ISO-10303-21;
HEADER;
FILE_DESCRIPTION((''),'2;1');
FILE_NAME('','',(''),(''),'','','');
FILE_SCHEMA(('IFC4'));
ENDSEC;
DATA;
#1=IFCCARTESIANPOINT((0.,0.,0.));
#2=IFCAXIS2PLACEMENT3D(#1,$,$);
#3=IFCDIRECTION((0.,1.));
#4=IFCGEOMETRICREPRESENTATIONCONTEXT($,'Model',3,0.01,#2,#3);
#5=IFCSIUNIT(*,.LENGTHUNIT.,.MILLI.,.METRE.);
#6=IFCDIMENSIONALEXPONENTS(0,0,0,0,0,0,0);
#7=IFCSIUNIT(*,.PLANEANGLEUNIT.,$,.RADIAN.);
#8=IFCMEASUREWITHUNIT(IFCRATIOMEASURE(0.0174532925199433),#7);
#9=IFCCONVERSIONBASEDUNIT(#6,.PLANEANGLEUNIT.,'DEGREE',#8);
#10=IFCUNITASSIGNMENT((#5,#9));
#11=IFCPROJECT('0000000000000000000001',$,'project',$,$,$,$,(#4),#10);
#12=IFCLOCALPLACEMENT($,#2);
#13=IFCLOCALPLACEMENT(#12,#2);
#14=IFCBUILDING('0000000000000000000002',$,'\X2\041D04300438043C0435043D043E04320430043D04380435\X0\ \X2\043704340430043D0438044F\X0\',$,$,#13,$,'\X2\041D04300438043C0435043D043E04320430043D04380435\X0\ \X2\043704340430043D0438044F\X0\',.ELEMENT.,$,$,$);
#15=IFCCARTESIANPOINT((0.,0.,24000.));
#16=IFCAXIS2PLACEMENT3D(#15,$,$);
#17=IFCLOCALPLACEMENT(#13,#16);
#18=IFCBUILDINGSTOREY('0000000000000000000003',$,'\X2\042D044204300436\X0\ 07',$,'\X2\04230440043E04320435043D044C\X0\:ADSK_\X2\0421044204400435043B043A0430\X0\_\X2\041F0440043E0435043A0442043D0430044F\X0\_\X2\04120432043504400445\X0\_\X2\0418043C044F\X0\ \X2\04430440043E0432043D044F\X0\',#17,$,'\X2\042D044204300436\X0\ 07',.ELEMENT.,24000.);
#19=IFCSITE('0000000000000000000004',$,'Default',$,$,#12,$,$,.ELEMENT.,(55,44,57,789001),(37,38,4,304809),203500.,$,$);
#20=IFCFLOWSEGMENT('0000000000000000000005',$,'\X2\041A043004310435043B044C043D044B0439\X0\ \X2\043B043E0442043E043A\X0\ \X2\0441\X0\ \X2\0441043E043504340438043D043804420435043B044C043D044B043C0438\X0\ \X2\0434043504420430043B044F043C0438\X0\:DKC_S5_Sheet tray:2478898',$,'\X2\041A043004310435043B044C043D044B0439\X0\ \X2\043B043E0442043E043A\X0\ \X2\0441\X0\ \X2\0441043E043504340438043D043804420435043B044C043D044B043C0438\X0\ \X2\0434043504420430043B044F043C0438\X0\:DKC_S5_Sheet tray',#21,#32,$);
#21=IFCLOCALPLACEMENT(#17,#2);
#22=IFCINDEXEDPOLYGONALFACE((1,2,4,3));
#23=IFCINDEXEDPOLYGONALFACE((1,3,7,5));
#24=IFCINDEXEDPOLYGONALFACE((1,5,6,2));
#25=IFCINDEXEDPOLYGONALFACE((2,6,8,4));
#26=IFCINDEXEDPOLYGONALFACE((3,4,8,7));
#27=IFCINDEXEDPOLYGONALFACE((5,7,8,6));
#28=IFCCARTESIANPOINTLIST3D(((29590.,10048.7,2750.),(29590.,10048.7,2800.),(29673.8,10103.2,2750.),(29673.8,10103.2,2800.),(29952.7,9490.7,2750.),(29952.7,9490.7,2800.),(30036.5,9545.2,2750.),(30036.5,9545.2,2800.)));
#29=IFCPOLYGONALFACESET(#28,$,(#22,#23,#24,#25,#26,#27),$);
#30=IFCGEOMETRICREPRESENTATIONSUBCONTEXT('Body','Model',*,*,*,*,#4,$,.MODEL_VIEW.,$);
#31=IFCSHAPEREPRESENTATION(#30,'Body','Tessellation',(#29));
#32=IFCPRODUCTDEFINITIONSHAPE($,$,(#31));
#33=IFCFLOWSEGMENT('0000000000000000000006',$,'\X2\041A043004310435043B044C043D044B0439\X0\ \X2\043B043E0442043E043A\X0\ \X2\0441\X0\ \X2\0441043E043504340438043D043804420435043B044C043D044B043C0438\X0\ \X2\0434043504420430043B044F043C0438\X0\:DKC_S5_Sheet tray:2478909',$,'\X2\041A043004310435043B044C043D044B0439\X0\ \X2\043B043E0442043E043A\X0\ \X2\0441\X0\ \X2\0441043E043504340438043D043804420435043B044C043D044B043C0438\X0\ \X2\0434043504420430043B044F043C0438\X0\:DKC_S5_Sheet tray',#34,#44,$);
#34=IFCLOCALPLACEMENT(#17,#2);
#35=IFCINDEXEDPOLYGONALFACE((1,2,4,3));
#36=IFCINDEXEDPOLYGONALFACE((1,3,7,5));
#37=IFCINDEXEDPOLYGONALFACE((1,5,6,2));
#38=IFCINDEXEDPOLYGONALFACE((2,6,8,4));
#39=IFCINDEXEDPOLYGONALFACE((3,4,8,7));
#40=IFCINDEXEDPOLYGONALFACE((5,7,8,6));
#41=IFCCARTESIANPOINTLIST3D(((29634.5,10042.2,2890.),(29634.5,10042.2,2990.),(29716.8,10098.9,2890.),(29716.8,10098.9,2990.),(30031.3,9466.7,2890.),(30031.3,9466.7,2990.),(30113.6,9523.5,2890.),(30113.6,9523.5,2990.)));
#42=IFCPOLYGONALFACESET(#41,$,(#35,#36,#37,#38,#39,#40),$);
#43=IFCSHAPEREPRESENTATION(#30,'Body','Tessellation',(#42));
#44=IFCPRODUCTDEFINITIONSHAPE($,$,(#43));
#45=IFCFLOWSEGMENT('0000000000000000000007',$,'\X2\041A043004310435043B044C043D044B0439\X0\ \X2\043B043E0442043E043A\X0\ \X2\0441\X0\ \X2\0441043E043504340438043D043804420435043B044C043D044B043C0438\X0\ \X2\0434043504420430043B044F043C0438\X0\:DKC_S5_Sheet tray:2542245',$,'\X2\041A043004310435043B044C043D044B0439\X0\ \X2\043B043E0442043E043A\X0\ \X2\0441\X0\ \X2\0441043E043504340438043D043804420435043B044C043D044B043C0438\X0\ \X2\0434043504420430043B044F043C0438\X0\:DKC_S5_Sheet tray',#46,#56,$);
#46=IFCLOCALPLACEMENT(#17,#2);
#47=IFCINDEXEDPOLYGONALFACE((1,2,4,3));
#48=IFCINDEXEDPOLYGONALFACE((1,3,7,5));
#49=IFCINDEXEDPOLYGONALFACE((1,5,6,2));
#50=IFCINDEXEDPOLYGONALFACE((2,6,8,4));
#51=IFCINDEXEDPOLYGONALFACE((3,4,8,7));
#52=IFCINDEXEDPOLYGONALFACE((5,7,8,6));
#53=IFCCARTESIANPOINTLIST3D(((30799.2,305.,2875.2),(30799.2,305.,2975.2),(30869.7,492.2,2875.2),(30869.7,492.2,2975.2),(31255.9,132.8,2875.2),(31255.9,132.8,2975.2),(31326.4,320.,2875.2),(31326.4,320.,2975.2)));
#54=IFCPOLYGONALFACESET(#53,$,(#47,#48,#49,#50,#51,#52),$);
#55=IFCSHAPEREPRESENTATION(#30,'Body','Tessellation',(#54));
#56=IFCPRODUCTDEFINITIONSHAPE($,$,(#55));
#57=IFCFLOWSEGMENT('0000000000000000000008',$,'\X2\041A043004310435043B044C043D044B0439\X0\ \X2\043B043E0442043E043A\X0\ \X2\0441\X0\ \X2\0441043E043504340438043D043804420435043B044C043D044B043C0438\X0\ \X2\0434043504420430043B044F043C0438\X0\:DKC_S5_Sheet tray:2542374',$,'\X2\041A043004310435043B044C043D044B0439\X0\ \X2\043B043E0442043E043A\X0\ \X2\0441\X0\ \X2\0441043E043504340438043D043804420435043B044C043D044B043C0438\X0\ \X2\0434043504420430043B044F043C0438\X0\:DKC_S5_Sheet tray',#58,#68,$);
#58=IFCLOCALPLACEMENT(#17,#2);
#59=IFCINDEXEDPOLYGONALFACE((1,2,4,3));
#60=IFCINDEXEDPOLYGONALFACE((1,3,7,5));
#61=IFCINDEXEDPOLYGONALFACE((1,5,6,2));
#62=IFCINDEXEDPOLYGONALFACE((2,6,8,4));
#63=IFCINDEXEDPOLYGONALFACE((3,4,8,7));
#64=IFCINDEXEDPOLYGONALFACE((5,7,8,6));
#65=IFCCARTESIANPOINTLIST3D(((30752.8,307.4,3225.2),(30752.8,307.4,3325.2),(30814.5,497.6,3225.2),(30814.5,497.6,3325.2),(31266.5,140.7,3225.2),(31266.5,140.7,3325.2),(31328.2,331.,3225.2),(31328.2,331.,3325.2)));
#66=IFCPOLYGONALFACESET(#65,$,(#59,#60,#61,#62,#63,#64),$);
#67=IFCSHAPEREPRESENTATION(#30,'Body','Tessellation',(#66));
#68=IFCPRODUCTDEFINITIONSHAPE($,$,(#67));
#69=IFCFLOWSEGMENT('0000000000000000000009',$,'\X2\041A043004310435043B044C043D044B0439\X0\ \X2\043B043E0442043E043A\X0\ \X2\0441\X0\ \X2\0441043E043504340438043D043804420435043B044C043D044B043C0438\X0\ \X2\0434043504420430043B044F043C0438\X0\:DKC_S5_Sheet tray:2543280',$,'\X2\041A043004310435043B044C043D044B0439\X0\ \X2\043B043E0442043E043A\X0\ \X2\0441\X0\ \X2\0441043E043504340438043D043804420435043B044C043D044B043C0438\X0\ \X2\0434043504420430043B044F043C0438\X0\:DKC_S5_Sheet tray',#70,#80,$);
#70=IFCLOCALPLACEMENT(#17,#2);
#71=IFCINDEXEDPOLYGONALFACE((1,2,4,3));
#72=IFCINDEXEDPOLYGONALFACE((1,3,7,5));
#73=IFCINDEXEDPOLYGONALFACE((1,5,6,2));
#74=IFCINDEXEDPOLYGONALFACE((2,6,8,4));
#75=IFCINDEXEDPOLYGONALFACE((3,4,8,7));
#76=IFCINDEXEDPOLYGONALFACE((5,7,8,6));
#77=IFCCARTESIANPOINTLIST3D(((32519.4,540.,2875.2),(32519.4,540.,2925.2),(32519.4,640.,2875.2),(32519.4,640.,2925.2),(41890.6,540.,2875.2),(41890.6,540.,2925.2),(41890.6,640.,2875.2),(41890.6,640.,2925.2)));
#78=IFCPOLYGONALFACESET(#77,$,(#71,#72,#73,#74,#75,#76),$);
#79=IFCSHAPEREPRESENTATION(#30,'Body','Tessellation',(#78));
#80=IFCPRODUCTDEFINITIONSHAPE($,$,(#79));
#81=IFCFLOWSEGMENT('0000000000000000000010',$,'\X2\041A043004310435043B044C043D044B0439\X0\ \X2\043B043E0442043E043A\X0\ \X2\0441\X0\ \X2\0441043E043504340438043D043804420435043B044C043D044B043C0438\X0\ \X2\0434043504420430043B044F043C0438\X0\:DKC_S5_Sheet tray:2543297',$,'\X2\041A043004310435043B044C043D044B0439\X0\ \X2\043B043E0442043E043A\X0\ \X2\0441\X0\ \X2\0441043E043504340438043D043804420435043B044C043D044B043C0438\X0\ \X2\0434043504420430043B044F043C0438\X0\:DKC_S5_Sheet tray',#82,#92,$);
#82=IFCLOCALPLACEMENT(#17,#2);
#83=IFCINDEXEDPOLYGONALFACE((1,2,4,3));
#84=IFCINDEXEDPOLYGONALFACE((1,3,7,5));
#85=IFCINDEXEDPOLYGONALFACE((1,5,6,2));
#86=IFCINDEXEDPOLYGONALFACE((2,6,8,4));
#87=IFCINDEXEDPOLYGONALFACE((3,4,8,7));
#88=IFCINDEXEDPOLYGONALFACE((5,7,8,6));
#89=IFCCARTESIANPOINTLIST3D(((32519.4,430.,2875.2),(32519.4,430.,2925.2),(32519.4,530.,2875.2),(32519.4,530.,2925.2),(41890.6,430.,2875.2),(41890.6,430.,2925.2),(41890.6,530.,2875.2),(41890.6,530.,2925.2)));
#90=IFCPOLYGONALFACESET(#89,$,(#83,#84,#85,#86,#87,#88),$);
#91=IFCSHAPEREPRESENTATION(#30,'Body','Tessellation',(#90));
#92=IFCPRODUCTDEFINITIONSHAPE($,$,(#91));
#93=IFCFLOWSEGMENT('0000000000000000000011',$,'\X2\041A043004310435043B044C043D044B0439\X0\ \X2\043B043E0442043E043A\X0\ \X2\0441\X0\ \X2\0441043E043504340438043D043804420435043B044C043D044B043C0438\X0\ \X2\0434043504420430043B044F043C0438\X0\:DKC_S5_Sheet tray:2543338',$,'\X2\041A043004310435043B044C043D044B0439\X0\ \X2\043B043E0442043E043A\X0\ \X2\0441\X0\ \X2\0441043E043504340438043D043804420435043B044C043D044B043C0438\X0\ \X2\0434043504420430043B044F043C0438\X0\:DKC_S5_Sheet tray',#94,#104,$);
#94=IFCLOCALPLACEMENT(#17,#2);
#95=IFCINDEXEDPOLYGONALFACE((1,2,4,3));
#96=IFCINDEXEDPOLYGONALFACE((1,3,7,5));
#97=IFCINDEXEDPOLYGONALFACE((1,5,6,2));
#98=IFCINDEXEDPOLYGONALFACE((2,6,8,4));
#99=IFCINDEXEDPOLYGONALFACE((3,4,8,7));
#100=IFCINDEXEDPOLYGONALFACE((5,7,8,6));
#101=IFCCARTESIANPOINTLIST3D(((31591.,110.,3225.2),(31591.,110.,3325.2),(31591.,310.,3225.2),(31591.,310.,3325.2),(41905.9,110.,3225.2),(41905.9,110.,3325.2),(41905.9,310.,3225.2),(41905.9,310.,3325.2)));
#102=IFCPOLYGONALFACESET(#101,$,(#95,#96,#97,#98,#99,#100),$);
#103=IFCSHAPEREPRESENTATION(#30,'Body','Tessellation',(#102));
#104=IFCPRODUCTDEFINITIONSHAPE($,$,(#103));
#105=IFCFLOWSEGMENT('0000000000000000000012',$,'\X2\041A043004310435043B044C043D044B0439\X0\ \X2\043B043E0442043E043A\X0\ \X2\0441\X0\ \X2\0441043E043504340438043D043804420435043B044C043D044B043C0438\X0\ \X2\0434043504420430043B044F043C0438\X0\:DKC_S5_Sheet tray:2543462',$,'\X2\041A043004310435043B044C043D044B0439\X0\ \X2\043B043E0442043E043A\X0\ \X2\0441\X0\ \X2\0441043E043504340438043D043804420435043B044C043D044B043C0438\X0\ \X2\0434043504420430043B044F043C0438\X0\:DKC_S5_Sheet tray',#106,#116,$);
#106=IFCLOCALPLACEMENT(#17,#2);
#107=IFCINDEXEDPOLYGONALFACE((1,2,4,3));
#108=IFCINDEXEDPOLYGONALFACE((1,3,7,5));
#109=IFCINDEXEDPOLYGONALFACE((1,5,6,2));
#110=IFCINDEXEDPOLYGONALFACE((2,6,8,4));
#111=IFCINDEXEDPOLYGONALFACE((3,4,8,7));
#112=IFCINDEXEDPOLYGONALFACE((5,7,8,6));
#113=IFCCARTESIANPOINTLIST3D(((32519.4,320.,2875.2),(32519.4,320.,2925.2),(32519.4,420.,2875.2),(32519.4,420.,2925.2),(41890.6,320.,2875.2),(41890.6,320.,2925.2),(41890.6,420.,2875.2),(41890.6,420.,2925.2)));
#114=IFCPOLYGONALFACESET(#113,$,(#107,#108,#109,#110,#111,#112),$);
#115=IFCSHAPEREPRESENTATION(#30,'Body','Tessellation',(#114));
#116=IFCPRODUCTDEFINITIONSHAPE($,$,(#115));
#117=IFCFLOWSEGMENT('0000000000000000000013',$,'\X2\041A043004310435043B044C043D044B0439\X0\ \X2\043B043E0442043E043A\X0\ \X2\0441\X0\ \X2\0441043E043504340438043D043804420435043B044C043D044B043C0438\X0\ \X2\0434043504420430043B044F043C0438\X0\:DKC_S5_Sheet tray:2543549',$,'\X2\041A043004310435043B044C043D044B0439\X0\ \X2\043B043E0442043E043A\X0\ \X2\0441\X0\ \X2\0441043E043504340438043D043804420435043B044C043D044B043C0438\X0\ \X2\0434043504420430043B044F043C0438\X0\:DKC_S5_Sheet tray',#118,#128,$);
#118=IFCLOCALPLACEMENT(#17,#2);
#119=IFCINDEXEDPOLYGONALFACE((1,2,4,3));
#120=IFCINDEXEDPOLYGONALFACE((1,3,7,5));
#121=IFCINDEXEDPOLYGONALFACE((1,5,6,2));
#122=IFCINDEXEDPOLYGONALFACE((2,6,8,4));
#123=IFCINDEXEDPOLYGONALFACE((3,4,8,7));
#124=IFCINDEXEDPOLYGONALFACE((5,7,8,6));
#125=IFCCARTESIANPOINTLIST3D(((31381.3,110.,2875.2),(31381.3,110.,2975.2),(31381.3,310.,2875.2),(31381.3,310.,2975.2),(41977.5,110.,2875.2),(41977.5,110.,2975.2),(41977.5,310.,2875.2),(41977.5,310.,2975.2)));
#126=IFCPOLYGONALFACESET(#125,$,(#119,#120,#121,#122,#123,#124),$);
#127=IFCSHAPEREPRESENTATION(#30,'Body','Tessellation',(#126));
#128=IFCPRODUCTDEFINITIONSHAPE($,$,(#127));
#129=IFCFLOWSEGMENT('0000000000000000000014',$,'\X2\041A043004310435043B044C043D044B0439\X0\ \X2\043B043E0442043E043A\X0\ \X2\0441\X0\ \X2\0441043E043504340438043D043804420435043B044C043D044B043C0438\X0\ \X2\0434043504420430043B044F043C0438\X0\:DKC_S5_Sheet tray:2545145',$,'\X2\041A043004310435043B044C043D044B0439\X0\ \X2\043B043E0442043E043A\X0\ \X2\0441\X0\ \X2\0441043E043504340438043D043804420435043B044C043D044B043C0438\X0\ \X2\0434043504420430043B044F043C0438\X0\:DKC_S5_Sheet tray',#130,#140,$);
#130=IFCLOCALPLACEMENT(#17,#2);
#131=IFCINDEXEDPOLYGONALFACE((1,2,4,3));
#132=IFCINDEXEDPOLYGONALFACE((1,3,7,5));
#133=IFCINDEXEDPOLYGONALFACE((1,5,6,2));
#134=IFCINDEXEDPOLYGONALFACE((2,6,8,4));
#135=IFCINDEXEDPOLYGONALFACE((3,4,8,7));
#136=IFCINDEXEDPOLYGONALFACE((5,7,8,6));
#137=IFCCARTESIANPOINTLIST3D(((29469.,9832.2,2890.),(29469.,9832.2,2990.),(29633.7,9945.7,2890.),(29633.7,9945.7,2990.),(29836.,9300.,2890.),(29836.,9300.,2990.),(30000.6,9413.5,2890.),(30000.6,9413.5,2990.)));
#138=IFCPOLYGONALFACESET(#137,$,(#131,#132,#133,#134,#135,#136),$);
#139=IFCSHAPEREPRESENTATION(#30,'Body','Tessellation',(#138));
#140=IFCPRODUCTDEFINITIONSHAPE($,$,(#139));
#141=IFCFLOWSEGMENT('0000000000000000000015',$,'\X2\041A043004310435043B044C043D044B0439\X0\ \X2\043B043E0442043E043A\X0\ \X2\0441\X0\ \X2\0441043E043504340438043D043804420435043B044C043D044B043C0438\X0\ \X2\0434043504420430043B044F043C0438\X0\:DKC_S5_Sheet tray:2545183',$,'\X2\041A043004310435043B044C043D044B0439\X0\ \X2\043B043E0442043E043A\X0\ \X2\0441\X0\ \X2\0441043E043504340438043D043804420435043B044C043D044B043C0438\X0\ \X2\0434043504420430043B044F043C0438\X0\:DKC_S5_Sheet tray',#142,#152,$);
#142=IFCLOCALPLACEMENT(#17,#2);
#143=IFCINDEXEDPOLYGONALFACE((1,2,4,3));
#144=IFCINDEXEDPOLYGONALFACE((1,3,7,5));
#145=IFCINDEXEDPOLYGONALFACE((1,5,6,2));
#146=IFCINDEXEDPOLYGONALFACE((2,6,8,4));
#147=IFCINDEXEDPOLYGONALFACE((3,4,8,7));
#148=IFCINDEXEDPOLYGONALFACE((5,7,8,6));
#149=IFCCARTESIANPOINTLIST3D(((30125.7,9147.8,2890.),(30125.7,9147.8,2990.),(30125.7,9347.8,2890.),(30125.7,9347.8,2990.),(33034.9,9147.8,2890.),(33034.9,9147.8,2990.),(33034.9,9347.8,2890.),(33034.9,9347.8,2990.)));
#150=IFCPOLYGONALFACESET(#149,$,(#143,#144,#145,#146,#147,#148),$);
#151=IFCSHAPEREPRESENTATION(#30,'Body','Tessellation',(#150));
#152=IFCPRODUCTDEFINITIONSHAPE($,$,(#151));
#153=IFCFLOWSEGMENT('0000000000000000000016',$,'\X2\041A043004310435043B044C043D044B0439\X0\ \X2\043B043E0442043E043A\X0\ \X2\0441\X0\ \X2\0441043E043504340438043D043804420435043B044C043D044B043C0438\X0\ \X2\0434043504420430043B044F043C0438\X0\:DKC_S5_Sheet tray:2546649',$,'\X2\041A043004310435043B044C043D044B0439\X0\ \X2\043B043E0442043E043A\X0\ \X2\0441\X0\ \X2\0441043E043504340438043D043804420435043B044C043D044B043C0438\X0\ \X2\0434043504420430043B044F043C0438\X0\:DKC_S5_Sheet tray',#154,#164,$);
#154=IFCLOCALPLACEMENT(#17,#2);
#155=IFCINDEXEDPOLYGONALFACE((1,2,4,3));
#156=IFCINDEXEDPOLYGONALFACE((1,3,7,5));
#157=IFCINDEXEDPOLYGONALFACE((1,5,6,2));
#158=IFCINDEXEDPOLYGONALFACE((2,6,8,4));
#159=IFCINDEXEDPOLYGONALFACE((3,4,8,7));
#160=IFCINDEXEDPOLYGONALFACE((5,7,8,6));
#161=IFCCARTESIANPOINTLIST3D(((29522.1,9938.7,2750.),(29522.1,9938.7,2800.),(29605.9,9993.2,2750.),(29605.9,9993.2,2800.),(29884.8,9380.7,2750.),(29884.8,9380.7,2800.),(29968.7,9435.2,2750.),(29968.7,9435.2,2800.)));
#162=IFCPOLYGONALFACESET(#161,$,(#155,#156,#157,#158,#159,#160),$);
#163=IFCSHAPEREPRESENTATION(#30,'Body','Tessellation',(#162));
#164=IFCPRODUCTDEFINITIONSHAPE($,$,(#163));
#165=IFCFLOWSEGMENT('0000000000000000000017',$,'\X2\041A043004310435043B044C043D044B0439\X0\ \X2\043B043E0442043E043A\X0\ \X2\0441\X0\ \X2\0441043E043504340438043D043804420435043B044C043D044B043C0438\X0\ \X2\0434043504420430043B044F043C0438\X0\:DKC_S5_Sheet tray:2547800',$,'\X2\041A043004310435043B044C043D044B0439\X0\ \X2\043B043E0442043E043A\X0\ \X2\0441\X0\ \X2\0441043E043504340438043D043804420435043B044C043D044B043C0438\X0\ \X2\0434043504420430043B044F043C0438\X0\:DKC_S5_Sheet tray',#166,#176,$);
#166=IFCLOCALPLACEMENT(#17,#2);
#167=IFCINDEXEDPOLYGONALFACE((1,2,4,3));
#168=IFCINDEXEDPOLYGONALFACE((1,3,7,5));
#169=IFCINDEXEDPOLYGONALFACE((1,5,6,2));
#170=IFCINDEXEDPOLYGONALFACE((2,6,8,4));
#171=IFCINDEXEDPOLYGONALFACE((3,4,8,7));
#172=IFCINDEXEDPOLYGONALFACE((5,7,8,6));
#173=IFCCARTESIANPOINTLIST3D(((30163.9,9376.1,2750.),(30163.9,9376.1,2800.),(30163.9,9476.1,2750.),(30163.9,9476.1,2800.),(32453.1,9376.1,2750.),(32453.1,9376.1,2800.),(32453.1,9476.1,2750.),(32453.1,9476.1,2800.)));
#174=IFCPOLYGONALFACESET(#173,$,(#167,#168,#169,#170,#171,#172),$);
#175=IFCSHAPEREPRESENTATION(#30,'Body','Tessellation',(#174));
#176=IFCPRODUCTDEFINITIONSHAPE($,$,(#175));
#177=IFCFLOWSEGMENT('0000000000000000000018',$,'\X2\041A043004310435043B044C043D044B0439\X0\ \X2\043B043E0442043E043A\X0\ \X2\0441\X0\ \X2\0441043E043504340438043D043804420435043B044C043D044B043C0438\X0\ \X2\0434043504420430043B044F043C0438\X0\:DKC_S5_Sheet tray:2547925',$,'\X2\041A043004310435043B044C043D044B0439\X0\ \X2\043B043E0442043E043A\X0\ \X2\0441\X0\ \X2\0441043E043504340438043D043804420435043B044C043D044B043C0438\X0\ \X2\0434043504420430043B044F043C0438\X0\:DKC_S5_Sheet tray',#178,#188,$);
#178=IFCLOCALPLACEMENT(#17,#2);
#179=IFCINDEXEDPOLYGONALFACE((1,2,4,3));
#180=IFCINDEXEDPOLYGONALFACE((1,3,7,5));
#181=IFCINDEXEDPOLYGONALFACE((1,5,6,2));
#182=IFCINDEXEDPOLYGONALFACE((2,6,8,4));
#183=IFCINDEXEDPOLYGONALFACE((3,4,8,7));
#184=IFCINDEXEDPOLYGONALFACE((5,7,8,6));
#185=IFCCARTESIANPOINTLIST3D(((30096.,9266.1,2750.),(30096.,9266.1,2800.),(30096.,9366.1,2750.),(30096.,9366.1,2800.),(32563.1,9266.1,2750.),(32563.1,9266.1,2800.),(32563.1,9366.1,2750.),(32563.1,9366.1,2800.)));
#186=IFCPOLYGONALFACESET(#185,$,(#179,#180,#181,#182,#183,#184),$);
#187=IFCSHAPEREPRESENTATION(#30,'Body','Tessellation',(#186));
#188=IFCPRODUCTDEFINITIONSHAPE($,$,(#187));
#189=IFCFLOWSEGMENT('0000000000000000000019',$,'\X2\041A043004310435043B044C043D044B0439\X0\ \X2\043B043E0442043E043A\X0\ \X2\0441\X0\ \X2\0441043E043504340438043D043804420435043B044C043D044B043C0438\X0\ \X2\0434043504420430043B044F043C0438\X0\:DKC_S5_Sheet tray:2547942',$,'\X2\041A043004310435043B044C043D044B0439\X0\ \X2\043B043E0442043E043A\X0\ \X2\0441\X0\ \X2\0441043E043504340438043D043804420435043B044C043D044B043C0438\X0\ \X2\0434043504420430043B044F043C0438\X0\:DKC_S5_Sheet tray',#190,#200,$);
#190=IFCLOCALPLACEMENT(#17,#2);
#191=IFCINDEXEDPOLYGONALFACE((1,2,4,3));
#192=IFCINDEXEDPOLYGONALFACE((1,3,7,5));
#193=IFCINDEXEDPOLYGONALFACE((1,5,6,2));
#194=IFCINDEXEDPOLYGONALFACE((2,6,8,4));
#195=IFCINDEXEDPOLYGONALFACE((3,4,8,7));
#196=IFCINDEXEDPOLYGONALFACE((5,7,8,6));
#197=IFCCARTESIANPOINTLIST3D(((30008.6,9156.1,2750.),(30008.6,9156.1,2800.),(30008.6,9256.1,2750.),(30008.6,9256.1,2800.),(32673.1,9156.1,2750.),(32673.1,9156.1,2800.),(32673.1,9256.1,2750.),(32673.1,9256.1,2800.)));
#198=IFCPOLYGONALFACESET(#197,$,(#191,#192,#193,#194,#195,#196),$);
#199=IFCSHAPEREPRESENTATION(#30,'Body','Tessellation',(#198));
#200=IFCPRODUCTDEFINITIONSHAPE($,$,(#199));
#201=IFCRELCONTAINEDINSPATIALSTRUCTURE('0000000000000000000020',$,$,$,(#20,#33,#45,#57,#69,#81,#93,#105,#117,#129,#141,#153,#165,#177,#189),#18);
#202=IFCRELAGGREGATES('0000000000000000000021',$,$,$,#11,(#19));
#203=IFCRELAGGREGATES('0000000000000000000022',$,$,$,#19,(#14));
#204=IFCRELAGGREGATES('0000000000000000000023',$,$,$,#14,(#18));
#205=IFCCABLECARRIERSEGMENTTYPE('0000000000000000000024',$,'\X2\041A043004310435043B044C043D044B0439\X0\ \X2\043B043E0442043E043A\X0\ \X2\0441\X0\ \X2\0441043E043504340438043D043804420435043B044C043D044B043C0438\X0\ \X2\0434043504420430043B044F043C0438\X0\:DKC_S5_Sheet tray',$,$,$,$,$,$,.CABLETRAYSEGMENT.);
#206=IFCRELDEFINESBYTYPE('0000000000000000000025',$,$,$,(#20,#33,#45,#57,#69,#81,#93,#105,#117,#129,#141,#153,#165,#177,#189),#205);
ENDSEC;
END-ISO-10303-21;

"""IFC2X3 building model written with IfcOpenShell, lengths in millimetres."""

from ifc_helpers import new_model, entity, si_unit, converted_unit, direction, frame, frame_2d, origin, origin_2d_with_axis, place, context, subcontext, project, spatial, rectangle, extrude, type_object, element, save


model = new_model("IFC2X3")

# Units and contexts
model_context = context("Model", 3, precision=0.01, world=origin(), true_north=direction((0.0, 1.0)))
body_context = subcontext(model_context, "Body", "Model", "MODEL_VIEW")
ifc_project = project(units=[si_unit("LENGTHUNIT", "METRE", prefix="MILLI"), converted_unit("PLANEANGLEUNIT", "DEGREE", entity("IfcRatioMeasure", 0.0174532925199433), si_unit("PLANEANGLEUNIT", "RADIAN"), dimensions=[0, 0, 0, 0, 0, 0, 0])], contexts=[model_context])

# Site, building, storey
site_placement = place(None, frame((0.0, 0.0, 0.0)))
site = spatial("IfcSite", under=ifc_project, at=site_placement, Name="Default", CompositionType="ELEMENT", RefLatitude=(55, 44, 57, 789001), RefLongitude=(37, 38, 4, 304809), RefElevation=203500.0)
building_placement = place(site_placement, origin())
building = spatial("IfcBuilding", under=site, at=building_placement, Name="Наименование здания", LongName="Наименование здания", CompositionType="ELEMENT")
storey_placement = place(building_placement, frame((0.0, 0.0, 24000.0)))
storey = spatial("IfcBuildingStorey", under=building, at=storey_placement, Name="Этаж 07", ObjectType="Уровень:ADSK_Стрелка_Проектная_Вверх_Имя уровня", LongName="Этаж 07", CompositionType="ELEMENT", Elevation=24000.0)

# Flow segments
cable_carrier_segment_type = type_object("IfcCableCarrierSegmentType", Name="Кабельный лоток с соединительными деталями:DKC_S5_Sheet tray", PredefinedType="CABLETRAYSEGMENT")
flow_segment_1_placement = place(storey_placement, frame((29590.0, 9490.7, 2750.0)))
element("IfcFlowSegment", 1, at=flow_segment_1_placement, inside=storey, type_object=cable_carrier_segment_type, Name="Кабельный лоток с соединительными деталями:DKC_S5_Sheet tray:2478898", ObjectType="Кабельный лоток с соединительными деталями:DKC_S5_Sheet tray", context=body_context, shape_type="SweptSolid", body=[
    extrude(rectangle(XDim=665.6, YDim=100.0, at=origin_2d_with_axis()), frame((223.3, 306.3, 0.0), z_axis=(0.0, 0.0, 1.0), x_axis=(0.544988, -0.838444, 0.0)), (0.0, 0.0, 1.0), 50.0),
])
flow_segment_2_placement = place(storey_placement, frame((29634.5, 9466.7, 2890.0)))
element("IfcFlowSegment", 2, at=flow_segment_2_placement, inside=storey, type_object=cable_carrier_segment_type, Name="Кабельный лоток с соединительными деталями:DKC_S5_Sheet tray:2478909", ObjectType="Кабельный лоток с соединительными деталями:DKC_S5_Sheet tray", context=body_context, shape_type="SweptSolid", body=[
    extrude(rectangle(XDim=699.0, YDim=100.0, at=frame_2d((0.0, 0.0), x_axis=(1.0, 0.0))), frame((239.6, 316.1, 0.0), z_axis=(0.0, 0.0, 1.0), x_axis=(0.567683, -0.823247, 0.0)), (0.0, 0.0, 1.0), 100.0),
])
flow_segment_3_placement = place(storey_placement, frame((30799.2, 132.8, 2875.2)))
element("IfcFlowSegment", 3, at=flow_segment_3_placement, inside=storey, type_object=cable_carrier_segment_type, Name="Кабельный лоток с соединительными деталями:DKC_S5_Sheet tray:2542245", ObjectType="Кабельный лоток с соединительными деталями:DKC_S5_Sheet tray", context=body_context, shape_type="SweptSolid", body=[
    extrude(rectangle(XDim=488.1, YDim=200.0, at=origin_2d_with_axis()), frame((263.6, 179.7, 0.0), z_axis=(0.0, 0.0, 1.0), x_axis=(0.935729, -0.352721, 0.0)), (0.0, 0.0, 1.0), 100.0),
])
flow_segment_4_placement = place(storey_placement, frame((30752.8, 140.7, 3225.2)))
element("IfcFlowSegment", 4, at=flow_segment_4_placement, inside=storey, type_object=cable_carrier_segment_type, Name="Кабельный лоток с соединительными деталями:DKC_S5_Sheet tray:2542374", ObjectType="Кабельный лоток с соединительными деталями:DKC_S5_Sheet tray", context=body_context, shape_type="SweptSolid", body=[
    extrude(rectangle(XDim=540.1, YDim=200.0, at=frame_2d((0.0, 0.0), x_axis=(1.0, 0.0))), frame((287.7, 178.4, 0.0), z_axis=(0.0, 0.0, 1.0), x_axis=(-0.951215, 0.308529, 0.0)), (0.0, 0.0, 1.0), 100.0),
])
flow_segment_5_placement = place(storey_placement, frame((32519.4, 540.0, 2875.2)))
element("IfcFlowSegment", 5, at=flow_segment_5_placement, inside=storey, type_object=cable_carrier_segment_type, Name="Кабельный лоток с соединительными деталями:DKC_S5_Sheet tray:2543280", ObjectType="Кабельный лоток с соединительными деталями:DKC_S5_Sheet tray", context=body_context, shape_type="SweptSolid", body=[
    extrude(rectangle(XDim=9371.2, YDim=100.0, at=frame_2d((0.0, 0.0), x_axis=(1.0, 0.0))), frame((4685.6, 50.0, 0.0)), (0.0, 0.0, 1.0), 50.0),
])
flow_segment_6_placement = place(storey_placement, frame((32519.4, 430.0, 2875.2)))
element("IfcFlowSegment", 6, at=flow_segment_6_placement, inside=storey, type_object=cable_carrier_segment_type, Name="Кабельный лоток с соединительными деталями:DKC_S5_Sheet tray:2543297", ObjectType="Кабельный лоток с соединительными деталями:DKC_S5_Sheet tray", context=body_context, shape_type="SweptSolid", body=[
    extrude(rectangle(XDim=9371.2, YDim=100.0, at=frame_2d((0.0, 0.0), x_axis=(1.0, 0.0))), frame((4685.6, 50.0, 0.0)), (0.0, 0.0, 1.0), 50.0),
])
flow_segment_7_placement = place(storey_placement, frame((31591.0, 110.0, 3225.2)))
element("IfcFlowSegment", 7, at=flow_segment_7_placement, inside=storey, type_object=cable_carrier_segment_type, Name="Кабельный лоток с соединительными деталями:DKC_S5_Sheet tray:2543338", ObjectType="Кабельный лоток с соединительными деталями:DKC_S5_Sheet tray", context=body_context, shape_type="SweptSolid", body=[
    extrude(rectangle(XDim=10314.9, YDim=200.0, at=frame_2d((0.0, 0.0), x_axis=(1.0, 0.0))), frame((5157.5, 100.0, 0.0)), (0.0, 0.0, 1.0), 100.0),
])
flow_segment_8_placement = place(storey_placement, frame((32519.4, 320.0, 2875.2)))
element("IfcFlowSegment", 8, at=flow_segment_8_placement, inside=storey, type_object=cable_carrier_segment_type, Name="Кабельный лоток с соединительными деталями:DKC_S5_Sheet tray:2543462", ObjectType="Кабельный лоток с соединительными деталями:DKC_S5_Sheet tray", context=body_context, shape_type="SweptSolid", body=[
    extrude(rectangle(XDim=9371.2, YDim=100.0, at=frame_2d((0.0, 0.0), x_axis=(1.0, 0.0))), frame((4685.6, 50.0, 0.0)), (0.0, 0.0, 1.0), 50.0),
])
flow_segment_9_placement = place(storey_placement, frame((31381.3, 110.0, 2875.2)))
element("IfcFlowSegment", 9, at=flow_segment_9_placement, inside=storey, type_object=cable_carrier_segment_type, Name="Кабельный лоток с соединительными деталями:DKC_S5_Sheet tray:2543549", ObjectType="Кабельный лоток с соединительными деталями:DKC_S5_Sheet tray", context=body_context, shape_type="SweptSolid", body=[
    extrude(rectangle(XDim=10596.2, YDim=200.0, at=frame_2d((0.0, 0.0), x_axis=(1.0, 0.0))), frame((5298.1, 100.0, 0.0)), (0.0, 0.0, 1.0), 100.0),
])
flow_segment_10_placement = place(storey_placement, frame((29469.0, 9300.0, 2890.0)))
element("IfcFlowSegment", 10, at=flow_segment_10_placement, inside=storey, type_object=cable_carrier_segment_type, Name="Кабельный лоток с соединительными деталями:DKC_S5_Sheet tray:2545145", ObjectType="Кабельный лоток с соединительными деталями:DKC_S5_Sheet tray", context=body_context, shape_type="SweptSolid", body=[
    extrude(rectangle(XDim=646.5, YDim=200.0, at=frame_2d((0.0, 0.0), x_axis=(1.0, 0.0))), frame((265.8, 322.9, 0.0), z_axis=(0.0, 0.0, 1.0), x_axis=(0.567683, -0.823247, 0.0)), (0.0, 0.0, 1.0), 100.0),
])
flow_segment_11_placement = place(storey_placement, frame((30125.7, 9147.8, 2890.0)))
element("IfcFlowSegment", 11, at=flow_segment_11_placement, inside=storey, type_object=cable_carrier_segment_type, Name="Кабельный лоток с соединительными деталями:DKC_S5_Sheet tray:2545183", ObjectType="Кабельный лоток с соединительными деталями:DKC_S5_Sheet tray", context=body_context, shape_type="SweptSolid", body=[
    extrude(rectangle(XDim=2909.2, YDim=200.0, at=frame_2d((0.0, 0.0), x_axis=(1.0, 0.0))), frame((1454.6, 100.0, 0.0)), (0.0, 0.0, 1.0), 100.0),
])
flow_segment_12_placement = place(storey_placement, frame((29522.1, 9380.7, 2750.0)))
element("IfcFlowSegment", 12, at=flow_segment_12_placement, inside=storey, type_object=cable_carrier_segment_type, Name="Кабельный лоток с соединительными деталями:DKC_S5_Sheet tray:2546649", ObjectType="Кабельный лоток с соединительными деталями:DKC_S5_Sheet tray", context=body_context, shape_type="SweptSolid", body=[
    extrude(rectangle(XDim=665.6, YDim=100.0, at=frame_2d((0.0, 0.0), x_axis=(1.0, 0.0))), frame((223.3, 306.3, 0.0), z_axis=(0.0, 0.0, 1.0), x_axis=(0.544988, -0.838444, 0.0)), (0.0, 0.0, 1.0), 50.0),
])
flow_segment_13_placement = place(storey_placement, frame((30163.9, 9376.1, 2750.0)))
element("IfcFlowSegment", 13, at=flow_segment_13_placement, inside=storey, type_object=cable_carrier_segment_type, Name="Кабельный лоток с соединительными деталями:DKC_S5_Sheet tray:2547800", ObjectType="Кабельный лоток с соединительными деталями:DKC_S5_Sheet tray", context=body_context, shape_type="SweptSolid", body=[
    extrude(rectangle(XDim=2289.2, YDim=100.0, at=origin_2d_with_axis()), frame((1144.6, 50.0, 0.0)), (0.0, 0.0, 1.0), 50.0),
])
flow_segment_14_placement = place(storey_placement, frame((30096.0, 9266.1, 2750.0)))
element("IfcFlowSegment", 14, at=flow_segment_14_placement, inside=storey, type_object=cable_carrier_segment_type, Name="Кабельный лоток с соединительными деталями:DKC_S5_Sheet tray:2547925", ObjectType="Кабельный лоток с соединительными деталями:DKC_S5_Sheet tray", context=body_context, shape_type="SweptSolid", body=[
    extrude(rectangle(XDim=2467.1, YDim=100.0, at=frame_2d((0.0, 0.0), x_axis=(1.0, 0.0))), frame((1233.6, 50.0, 0.0)), (0.0, 0.0, 1.0), 50.0),
])
flow_segment_15_placement = place(storey_placement, frame((30008.6, 9156.1, 2750.0)))
element("IfcFlowSegment", 15, at=flow_segment_15_placement, inside=storey, type_object=cable_carrier_segment_type, Name="Кабельный лоток с соединительными деталями:DKC_S5_Sheet tray:2547942", ObjectType="Кабельный лоток с соединительными деталями:DKC_S5_Sheet tray", context=body_context, shape_type="SweptSolid", body=[
    extrude(rectangle(XDim=2664.5, YDim=100.0, at=frame_2d((0.0, 0.0), x_axis=(1.0, 0.0))), frame((1332.3, 50.0, 0.0)), (0.0, 0.0, 1.0), 50.0),
])

save(model, "model.ifc")
